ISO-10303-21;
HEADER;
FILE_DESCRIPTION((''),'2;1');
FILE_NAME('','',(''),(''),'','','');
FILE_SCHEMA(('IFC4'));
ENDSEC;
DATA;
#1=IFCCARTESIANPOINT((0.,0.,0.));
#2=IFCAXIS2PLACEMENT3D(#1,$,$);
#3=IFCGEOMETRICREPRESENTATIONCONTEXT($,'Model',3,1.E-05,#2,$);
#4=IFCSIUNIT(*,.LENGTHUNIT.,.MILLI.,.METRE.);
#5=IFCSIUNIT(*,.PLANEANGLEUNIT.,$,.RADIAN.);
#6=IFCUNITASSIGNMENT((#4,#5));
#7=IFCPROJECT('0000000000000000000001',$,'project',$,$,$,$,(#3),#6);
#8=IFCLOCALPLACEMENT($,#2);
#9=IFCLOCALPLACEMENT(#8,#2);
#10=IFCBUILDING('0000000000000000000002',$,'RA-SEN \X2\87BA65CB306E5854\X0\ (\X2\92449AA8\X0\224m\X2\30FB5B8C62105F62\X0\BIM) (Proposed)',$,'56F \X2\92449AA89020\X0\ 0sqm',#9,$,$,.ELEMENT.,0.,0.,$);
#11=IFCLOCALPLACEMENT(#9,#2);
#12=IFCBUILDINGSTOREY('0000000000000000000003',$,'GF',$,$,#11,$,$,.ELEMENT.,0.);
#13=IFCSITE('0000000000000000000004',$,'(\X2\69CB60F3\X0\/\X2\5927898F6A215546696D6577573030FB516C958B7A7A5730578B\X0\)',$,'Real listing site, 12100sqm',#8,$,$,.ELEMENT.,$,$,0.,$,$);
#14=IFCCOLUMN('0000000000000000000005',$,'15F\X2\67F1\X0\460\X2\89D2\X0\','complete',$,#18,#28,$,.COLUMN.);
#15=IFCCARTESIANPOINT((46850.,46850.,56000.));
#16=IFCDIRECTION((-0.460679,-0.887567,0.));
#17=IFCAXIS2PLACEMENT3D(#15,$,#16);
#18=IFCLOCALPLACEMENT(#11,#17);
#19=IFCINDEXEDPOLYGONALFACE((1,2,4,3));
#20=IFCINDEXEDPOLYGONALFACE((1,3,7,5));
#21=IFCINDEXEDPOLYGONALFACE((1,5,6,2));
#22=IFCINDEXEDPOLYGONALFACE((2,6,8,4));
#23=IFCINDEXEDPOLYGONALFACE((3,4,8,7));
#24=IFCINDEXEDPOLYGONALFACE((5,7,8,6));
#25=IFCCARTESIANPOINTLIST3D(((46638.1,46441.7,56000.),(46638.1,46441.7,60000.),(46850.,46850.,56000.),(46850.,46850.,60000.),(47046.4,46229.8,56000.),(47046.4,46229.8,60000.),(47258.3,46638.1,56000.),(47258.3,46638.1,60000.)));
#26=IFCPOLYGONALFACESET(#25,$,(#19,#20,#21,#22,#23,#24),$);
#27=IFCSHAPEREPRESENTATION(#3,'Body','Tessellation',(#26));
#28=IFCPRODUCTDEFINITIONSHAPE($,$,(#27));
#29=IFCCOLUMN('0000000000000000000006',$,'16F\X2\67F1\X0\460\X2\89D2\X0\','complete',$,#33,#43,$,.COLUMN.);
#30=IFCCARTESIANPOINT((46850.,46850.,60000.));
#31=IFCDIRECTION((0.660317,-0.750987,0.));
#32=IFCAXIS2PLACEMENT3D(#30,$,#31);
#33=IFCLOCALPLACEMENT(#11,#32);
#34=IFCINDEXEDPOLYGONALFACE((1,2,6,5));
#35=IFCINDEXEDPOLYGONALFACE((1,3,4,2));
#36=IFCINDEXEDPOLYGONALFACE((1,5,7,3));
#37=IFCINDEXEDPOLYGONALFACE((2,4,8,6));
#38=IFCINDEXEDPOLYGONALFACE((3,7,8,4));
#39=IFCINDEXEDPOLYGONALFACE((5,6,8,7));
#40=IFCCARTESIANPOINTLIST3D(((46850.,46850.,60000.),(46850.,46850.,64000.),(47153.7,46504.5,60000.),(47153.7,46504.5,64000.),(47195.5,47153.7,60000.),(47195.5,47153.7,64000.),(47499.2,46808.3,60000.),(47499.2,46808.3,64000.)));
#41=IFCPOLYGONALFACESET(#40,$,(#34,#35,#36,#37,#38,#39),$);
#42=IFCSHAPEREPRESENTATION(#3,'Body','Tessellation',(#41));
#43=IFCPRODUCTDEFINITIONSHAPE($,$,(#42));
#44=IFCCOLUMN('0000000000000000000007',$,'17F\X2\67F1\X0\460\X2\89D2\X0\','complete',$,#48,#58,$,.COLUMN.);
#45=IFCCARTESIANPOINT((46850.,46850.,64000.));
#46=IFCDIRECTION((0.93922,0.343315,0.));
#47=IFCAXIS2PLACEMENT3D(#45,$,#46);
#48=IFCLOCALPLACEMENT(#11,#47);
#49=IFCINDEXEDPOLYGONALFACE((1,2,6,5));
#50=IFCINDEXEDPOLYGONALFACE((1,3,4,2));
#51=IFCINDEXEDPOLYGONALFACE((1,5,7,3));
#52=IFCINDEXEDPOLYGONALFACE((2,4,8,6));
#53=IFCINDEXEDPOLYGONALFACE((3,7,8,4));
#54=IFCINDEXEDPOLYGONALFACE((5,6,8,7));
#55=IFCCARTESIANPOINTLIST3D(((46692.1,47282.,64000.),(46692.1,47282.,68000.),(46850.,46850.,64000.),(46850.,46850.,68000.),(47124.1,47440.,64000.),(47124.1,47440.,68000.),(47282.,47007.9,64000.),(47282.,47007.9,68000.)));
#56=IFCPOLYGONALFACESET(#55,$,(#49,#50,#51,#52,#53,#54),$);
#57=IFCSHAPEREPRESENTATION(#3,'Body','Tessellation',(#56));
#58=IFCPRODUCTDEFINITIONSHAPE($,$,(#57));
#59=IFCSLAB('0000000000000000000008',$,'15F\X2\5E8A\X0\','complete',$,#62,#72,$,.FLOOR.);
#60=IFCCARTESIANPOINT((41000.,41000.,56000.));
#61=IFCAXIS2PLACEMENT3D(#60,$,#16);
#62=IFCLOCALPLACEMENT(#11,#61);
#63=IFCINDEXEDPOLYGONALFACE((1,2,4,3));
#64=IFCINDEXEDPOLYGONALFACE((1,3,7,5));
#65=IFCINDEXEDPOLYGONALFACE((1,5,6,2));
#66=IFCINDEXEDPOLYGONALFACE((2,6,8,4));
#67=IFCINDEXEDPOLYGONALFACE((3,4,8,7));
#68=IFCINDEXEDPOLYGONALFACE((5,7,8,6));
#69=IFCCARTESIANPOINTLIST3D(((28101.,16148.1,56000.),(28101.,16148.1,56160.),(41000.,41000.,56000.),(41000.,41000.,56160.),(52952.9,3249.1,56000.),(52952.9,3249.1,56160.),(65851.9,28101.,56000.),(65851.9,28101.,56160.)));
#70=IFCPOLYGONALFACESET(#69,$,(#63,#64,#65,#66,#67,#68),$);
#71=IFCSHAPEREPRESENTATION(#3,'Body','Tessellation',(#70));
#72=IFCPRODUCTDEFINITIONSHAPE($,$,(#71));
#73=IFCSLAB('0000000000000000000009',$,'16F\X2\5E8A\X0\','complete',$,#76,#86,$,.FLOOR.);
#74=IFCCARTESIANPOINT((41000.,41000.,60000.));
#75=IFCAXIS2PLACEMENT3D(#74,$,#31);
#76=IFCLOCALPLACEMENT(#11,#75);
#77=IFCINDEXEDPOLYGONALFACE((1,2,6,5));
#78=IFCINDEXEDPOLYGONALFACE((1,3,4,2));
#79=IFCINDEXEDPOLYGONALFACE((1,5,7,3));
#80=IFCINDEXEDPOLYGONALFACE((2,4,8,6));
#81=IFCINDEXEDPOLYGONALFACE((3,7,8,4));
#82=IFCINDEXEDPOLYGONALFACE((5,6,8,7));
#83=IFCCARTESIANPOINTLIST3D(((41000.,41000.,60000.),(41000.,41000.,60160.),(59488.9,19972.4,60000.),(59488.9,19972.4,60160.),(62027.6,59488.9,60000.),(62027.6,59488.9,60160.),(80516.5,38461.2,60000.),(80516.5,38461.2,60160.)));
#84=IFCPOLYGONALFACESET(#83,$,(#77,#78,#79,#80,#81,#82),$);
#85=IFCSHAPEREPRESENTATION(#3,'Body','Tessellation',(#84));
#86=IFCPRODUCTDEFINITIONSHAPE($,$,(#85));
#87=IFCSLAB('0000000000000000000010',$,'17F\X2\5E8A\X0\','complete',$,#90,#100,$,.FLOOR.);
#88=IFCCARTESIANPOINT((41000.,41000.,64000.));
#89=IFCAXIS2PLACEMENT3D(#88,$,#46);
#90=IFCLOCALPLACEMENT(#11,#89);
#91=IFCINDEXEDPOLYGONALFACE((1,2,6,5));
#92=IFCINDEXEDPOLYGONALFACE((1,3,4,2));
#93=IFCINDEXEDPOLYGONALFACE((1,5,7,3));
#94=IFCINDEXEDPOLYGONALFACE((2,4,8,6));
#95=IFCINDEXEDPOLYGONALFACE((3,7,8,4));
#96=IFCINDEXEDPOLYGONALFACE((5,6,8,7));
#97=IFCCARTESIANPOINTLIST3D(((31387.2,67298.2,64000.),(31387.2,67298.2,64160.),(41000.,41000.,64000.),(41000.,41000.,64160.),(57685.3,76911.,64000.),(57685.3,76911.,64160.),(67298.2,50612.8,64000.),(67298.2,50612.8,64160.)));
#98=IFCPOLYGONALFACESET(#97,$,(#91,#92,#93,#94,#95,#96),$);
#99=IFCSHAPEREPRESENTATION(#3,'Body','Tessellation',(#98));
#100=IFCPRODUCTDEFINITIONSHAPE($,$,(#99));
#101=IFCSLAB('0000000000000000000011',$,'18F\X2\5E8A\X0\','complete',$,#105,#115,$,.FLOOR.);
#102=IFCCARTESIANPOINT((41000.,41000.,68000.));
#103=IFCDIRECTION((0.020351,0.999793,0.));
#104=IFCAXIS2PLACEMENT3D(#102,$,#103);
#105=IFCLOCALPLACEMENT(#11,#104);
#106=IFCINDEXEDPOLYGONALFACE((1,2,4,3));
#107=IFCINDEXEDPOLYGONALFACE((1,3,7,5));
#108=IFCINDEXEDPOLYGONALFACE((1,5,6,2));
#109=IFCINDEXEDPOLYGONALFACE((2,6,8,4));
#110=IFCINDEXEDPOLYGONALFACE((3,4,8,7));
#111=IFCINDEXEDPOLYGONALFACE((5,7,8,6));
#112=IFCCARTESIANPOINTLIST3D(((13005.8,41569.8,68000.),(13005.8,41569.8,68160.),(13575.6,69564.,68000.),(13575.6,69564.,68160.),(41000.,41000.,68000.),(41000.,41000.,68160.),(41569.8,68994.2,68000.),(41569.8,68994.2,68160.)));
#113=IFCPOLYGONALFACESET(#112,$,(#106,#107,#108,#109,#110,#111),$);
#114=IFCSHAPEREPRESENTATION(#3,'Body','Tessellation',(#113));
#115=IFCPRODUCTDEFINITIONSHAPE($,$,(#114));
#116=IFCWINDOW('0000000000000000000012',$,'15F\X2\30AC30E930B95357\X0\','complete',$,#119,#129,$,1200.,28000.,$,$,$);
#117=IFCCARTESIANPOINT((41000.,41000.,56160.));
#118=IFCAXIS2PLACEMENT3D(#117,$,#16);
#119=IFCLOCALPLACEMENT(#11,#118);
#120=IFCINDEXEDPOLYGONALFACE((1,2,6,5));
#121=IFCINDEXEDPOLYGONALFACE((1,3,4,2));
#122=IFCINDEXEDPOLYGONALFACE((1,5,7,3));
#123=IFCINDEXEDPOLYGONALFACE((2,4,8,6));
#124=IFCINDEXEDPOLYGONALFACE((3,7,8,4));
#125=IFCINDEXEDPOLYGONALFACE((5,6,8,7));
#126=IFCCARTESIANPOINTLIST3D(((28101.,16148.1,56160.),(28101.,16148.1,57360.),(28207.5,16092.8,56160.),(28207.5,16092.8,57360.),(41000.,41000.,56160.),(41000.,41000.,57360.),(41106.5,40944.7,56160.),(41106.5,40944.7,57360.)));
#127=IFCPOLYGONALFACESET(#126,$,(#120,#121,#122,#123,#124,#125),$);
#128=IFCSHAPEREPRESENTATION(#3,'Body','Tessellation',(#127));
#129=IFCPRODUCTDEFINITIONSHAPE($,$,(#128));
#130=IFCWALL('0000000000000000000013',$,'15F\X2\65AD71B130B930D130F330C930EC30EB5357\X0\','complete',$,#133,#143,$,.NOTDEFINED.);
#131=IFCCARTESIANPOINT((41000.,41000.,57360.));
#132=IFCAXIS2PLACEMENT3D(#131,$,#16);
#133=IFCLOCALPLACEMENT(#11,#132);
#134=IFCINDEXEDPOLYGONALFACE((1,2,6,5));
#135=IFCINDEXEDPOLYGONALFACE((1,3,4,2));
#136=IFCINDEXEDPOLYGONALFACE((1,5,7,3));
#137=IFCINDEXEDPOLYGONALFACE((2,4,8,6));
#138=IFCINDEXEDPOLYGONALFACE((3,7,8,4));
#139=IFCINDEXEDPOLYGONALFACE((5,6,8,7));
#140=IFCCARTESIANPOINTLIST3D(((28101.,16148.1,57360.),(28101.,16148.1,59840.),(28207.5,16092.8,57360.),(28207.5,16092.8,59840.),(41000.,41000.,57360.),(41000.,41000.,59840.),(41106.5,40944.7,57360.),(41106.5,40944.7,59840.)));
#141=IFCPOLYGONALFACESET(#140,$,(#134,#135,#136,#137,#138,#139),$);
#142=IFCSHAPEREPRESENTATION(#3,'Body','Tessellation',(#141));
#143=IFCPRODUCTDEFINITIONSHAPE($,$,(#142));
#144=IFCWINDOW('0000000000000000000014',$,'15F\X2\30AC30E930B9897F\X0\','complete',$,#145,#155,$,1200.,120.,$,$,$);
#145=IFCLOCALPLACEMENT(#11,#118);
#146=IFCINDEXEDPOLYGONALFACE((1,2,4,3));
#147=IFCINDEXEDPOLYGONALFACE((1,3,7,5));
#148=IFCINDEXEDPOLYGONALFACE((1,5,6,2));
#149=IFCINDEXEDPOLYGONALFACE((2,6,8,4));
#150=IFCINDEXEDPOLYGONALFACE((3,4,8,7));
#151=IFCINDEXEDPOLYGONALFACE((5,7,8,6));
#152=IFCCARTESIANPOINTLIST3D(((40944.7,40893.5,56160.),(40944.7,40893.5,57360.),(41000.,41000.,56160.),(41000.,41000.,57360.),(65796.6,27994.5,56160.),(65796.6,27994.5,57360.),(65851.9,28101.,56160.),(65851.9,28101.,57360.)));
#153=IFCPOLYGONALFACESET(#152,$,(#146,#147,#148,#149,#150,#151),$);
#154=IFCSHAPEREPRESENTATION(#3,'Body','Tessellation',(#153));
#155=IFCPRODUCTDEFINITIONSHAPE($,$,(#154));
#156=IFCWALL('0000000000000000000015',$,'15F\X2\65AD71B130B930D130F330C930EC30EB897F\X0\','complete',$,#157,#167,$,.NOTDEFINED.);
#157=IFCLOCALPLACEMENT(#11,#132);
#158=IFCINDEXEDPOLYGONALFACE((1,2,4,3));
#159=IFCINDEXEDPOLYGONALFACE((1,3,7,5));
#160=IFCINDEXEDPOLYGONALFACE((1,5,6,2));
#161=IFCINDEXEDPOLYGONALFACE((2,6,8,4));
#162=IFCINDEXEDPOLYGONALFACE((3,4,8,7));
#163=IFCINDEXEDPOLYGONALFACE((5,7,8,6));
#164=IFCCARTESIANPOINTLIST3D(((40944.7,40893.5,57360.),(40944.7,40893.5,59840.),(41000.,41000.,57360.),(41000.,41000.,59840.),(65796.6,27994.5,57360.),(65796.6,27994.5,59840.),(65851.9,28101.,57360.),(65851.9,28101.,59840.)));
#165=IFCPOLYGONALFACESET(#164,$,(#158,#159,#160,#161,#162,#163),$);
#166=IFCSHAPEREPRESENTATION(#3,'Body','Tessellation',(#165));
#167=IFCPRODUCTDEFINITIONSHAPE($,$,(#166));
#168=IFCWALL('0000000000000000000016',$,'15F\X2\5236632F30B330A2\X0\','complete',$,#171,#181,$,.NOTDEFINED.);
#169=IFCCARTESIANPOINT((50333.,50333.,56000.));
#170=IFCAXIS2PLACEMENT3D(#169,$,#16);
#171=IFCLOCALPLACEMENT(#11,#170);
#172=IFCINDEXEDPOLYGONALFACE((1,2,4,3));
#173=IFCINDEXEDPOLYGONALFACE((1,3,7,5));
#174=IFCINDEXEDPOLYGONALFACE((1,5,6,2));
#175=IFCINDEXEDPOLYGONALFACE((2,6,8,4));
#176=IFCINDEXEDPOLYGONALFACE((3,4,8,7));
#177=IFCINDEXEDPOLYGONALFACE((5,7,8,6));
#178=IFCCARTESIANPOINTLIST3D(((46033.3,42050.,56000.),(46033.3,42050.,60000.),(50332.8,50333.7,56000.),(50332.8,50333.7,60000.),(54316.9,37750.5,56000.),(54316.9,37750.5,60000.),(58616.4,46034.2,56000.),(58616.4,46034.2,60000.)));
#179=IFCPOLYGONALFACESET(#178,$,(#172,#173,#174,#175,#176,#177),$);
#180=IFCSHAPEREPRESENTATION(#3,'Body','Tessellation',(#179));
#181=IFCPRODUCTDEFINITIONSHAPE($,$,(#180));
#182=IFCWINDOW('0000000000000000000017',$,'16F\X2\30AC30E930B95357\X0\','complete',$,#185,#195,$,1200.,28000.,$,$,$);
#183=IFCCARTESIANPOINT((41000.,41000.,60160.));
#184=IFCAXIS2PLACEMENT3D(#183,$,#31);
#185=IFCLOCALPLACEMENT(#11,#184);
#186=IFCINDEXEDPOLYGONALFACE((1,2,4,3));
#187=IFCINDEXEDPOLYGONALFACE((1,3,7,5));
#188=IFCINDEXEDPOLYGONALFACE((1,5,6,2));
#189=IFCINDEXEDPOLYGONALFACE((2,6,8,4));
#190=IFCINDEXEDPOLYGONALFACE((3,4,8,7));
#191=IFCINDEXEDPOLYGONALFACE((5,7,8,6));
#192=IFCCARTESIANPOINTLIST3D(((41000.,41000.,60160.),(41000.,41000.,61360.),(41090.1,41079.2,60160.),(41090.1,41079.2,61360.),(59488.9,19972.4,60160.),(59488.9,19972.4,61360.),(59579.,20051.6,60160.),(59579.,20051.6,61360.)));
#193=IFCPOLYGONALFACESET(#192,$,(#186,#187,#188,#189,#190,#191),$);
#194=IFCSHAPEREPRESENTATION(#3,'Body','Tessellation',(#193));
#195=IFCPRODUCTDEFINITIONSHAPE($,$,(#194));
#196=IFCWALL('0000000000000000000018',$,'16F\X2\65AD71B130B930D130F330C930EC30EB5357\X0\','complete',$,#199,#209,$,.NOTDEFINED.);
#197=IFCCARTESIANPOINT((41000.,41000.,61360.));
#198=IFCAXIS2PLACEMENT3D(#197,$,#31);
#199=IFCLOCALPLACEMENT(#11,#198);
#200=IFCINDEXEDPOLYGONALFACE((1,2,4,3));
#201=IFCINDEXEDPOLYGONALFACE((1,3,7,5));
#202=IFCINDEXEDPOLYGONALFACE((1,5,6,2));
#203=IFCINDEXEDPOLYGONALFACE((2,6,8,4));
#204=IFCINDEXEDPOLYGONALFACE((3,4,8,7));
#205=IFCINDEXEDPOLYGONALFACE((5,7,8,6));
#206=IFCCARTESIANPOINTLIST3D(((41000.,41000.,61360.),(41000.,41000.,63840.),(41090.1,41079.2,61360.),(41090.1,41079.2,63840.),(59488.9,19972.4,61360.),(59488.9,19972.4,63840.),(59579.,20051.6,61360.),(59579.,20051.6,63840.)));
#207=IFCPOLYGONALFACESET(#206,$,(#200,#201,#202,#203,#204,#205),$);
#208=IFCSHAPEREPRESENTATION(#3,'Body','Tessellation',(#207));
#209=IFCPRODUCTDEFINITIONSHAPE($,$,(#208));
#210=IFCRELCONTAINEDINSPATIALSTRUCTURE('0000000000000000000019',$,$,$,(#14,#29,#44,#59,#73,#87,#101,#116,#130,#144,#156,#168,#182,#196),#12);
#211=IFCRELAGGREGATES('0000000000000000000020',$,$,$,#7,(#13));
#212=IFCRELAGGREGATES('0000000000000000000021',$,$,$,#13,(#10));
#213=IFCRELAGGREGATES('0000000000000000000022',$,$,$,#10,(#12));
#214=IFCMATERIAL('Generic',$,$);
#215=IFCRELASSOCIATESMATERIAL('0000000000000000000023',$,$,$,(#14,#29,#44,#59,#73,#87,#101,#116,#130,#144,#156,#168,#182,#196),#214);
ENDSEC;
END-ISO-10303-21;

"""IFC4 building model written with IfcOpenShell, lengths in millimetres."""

from ifc_helpers import new_model, si_unit, frame, frame_2d, origin, place, context, project, spatial, rectangle, extrude, material, element, save


model = new_model("IFC4")

# Units and contexts
model_context = context("Model", 3, precision=1e-05, world=origin())
ifc_project = project(units=[si_unit("LENGTHUNIT", "METRE", prefix="MILLI"), si_unit("PLANEANGLEUNIT", "RADIAN")], contexts=[model_context])

# Site, building, storey
site_placement = place(None, origin())
site = spatial("IfcSite", under=ifc_project, at=site_placement, Name="(構想/大規模商業敷地・公開空地型)", ObjectType="Real listing site, 12100sqm", CompositionType="ELEMENT", RefElevation=0.0)
building_placement = place(site_placement, origin())
building = spatial("IfcBuilding", under=site, at=building_placement, Name="RA-SEN 螺旋の塔 (鉄骨224m・完成形BIM) (Proposed)", ObjectType="56F 鉄骨造 0sqm", CompositionType="ELEMENT", ElevationOfRefHeight=0.0, ElevationOfTerrain=0.0)
storey_placement = place(building_placement, origin())
storey = spatial("IfcBuildingStorey", under=building, at=storey_placement, Name="GF", CompositionType="ELEMENT", Elevation=0.0)

# Columns
ifc_material = material(Name="Generic")
column_1_placement = place(storey_placement, frame((46850.0, 46850.0, 56000.0), x_axis=(-0.460679, -0.887567, 0.0)))
element("IfcColumn", 1, at=column_1_placement, inside=storey, material=ifc_material, Name="15F柱460角", Description="complete", PredefinedType="COLUMN", context=model_context, shape_type="SweptSolid", body=[
    extrude(rectangle(XDim=460.0, YDim=460.0, at=frame_2d((230.0, 230.0))), frame((46850.0, 46850.0, 56000.0), x_axis=(-0.460679, -0.887567, 0.0)), (0.0, 0.0, 1.0), 4000.0),
])
column_2_placement = place(storey_placement, frame((46850.0, 46850.0, 60000.0), x_axis=(0.660317, -0.750987, 0.0)))
element("IfcColumn", 2, at=column_2_placement, inside=storey, material=ifc_material, Name="16F柱460角", Description="complete", PredefinedType="COLUMN", context=model_context, shape_type="SweptSolid", body=[
    extrude(rectangle(XDim=460.0, YDim=460.0, at=frame_2d((230.0, 230.0))), frame((46850.0, 46850.0, 60000.0), x_axis=(0.660317, -0.750987, 0.0)), (0.0, 0.0, 1.0), 4000.0),
])
column_3_placement = place(storey_placement, frame((46850.0, 46850.0, 64000.0), x_axis=(0.93922, 0.343315, 0.0)))
element("IfcColumn", 3, at=column_3_placement, inside=storey, material=ifc_material, Name="17F柱460角", Description="complete", PredefinedType="COLUMN", context=model_context, shape_type="SweptSolid", body=[
    extrude(rectangle(XDim=460.0, YDim=460.0, at=frame_2d((230.0, 230.0))), frame((46850.0, 46850.0, 64000.0), x_axis=(0.93922, 0.343315, 0.0)), (0.0, 0.0, 1.0), 4000.0),
])

# Slabs
slab_1_placement = place(storey_placement, frame((41000.0, 41000.0, 56000.0), x_axis=(-0.460679, -0.887567, 0.0)))
element("IfcSlab", 4, at=slab_1_placement, inside=storey, material=ifc_material, Name="15F床", Description="complete", PredefinedType="FLOOR", context=model_context, shape_type="SweptSolid", body=[
    extrude(rectangle(XDim=28000.0, YDim=28000.0, at=frame_2d((14000.0, 14000.0))), frame((41000.0, 41000.0, 56000.0), x_axis=(-0.460679, -0.887567, 0.0)), (0.0, 0.0, 1.0), 160.0),
])
slab_2_placement = place(storey_placement, frame((41000.0, 41000.0, 60000.0), x_axis=(0.660317, -0.750987, 0.0)))
element("IfcSlab", 5, at=slab_2_placement, inside=storey, material=ifc_material, Name="16F床", Description="complete", PredefinedType="FLOOR", context=model_context, shape_type="SweptSolid", body=[
    extrude(rectangle(XDim=28000.0, YDim=28000.0, at=frame_2d((14000.0, 14000.0))), frame((41000.0, 41000.0, 60000.0), x_axis=(0.660317, -0.750987, 0.0)), (0.0, 0.0, 1.0), 160.0),
])
slab_3_placement = place(storey_placement, frame((41000.0, 41000.0, 64000.0), x_axis=(0.93922, 0.343315, 0.0)))
element("IfcSlab", 6, at=slab_3_placement, inside=storey, material=ifc_material, Name="17F床", Description="complete", PredefinedType="FLOOR", context=model_context, shape_type="SweptSolid", body=[
    extrude(rectangle(XDim=28000.0, YDim=28000.0, at=frame_2d((14000.0, 14000.0))), frame((41000.0, 41000.0, 64000.0), x_axis=(0.93922, 0.343315, 0.0)), (0.0, 0.0, 1.0), 160.0),
])
slab_4_placement = place(storey_placement, frame((41000.0, 41000.0, 68000.0), x_axis=(0.020351, 0.999793, 0.0)))
element("IfcSlab", 7, at=slab_4_placement, inside=storey, material=ifc_material, Name="18F床", Description="complete", PredefinedType="FLOOR", context=model_context, shape_type="SweptSolid", body=[
    extrude(rectangle(XDim=28000.0, YDim=28000.0, at=frame_2d((14000.0, 14000.0))), frame((41000.0, 41000.0, 68000.0), x_axis=(0.020351, 0.999793, 0.0)), (0.0, 0.0, 1.0), 160.0),
])

# Window
window_1_placement = place(storey_placement, frame((41000.0, 41000.0, 56160.0), x_axis=(-0.460679, -0.887567, 0.0)))
element("IfcWindow", 8, at=window_1_placement, inside=storey, material=ifc_material, Name="15Fガラス南", Description="complete", OverallHeight=1200.0, OverallWidth=28000.0, context=model_context, shape_type="SweptSolid", body=[
    extrude(rectangle(XDim=28000.0, YDim=120.0, at=frame_2d((14000.0, 60.0))), frame((41000.0, 41000.0, 56160.0), x_axis=(-0.460679, -0.887567, 0.0)), (0.0, 0.0, 1.0), 1200.0),
])

# Wall
wall_1_placement = place(storey_placement, frame((41000.0, 41000.0, 57360.0), x_axis=(-0.460679, -0.887567, 0.0)))
element("IfcWall", 9, at=wall_1_placement, inside=storey, material=ifc_material, Name="15F断熱スパンドレル南", Description="complete", PredefinedType="NOTDEFINED", context=model_context, shape_type="SweptSolid", body=[
    extrude(rectangle(XDim=28000.0, YDim=120.0, at=frame_2d((14000.0, 60.0))), frame((41000.0, 41000.0, 57360.0), x_axis=(-0.460679, -0.887567, 0.0)), (0.0, 0.0, 1.0), 2480.0),
])

# Window
window_2_placement = place(storey_placement, frame((41000.0, 41000.0, 56160.0), x_axis=(-0.460679, -0.887567, 0.0)))
element("IfcWindow", 10, at=window_2_placement, inside=storey, material=ifc_material, Name="15Fガラス西", Description="complete", OverallHeight=1200.0, OverallWidth=120.0, context=model_context, shape_type="SweptSolid", body=[
    extrude(rectangle(XDim=120.0, YDim=28000.0, at=frame_2d((60.0, 14000.0))), frame((41000.0, 41000.0, 56160.0), x_axis=(-0.460679, -0.887567, 0.0)), (0.0, 0.0, 1.0), 1200.0),
])

# Walls
wall_2_placement = place(storey_placement, frame((41000.0, 41000.0, 57360.0), x_axis=(-0.460679, -0.887567, 0.0)))
element("IfcWall", 11, at=wall_2_placement, inside=storey, material=ifc_material, Name="15F断熱スパンドレル西", Description="complete", PredefinedType="NOTDEFINED", context=model_context, shape_type="SweptSolid", body=[
    extrude(rectangle(XDim=120.0, YDim=28000.0, at=frame_2d((60.0, 14000.0))), frame((41000.0, 41000.0, 57360.0), x_axis=(-0.460679, -0.887567, 0.0)), (0.0, 0.0, 1.0), 2480.0),
])
wall_3_placement = place(storey_placement, frame((50333.0, 50333.0, 56000.0), x_axis=(-0.460679, -0.887567, 0.0)))
element("IfcWall", 12, at=wall_3_placement, inside=storey, material=ifc_material, Name="15F制振コア", Description="complete", PredefinedType="NOTDEFINED", context=model_context, shape_type="SweptSolid", body=[
    extrude(rectangle(XDim=9333.0, YDim=9333.0, at=frame_2d((4666.0, 4666.0))), frame((50333.0, 50333.0, 56000.0), x_axis=(-0.460679, -0.887567, 0.0)), (0.0, 0.0, 1.0), 4000.0),
])

# Window
window_3_placement = place(storey_placement, frame((41000.0, 41000.0, 60160.0), x_axis=(0.660317, -0.750987, 0.0)))
element("IfcWindow", 13, at=window_3_placement, inside=storey, material=ifc_material, Name="16Fガラス南", Description="complete", OverallHeight=1200.0, OverallWidth=28000.0, context=model_context, shape_type="SweptSolid", body=[
    extrude(rectangle(XDim=28000.0, YDim=120.0, at=frame_2d((14000.0, 60.0))), frame((41000.0, 41000.0, 60160.0), x_axis=(0.660317, -0.750987, 0.0)), (0.0, 0.0, 1.0), 1200.0),
])

# Wall
wall_4_placement = place(storey_placement, frame((41000.0, 41000.0, 61360.0), x_axis=(0.660317, -0.750987, 0.0)))
element("IfcWall", 14, at=wall_4_placement, inside=storey, material=ifc_material, Name="16F断熱スパンドレル南", Description="complete", PredefinedType="NOTDEFINED", context=model_context, shape_type="SweptSolid", body=[
    extrude(rectangle(XDim=28000.0, YDim=120.0, at=frame_2d((14000.0, 60.0))), frame((41000.0, 41000.0, 61360.0), x_axis=(0.660317, -0.750987, 0.0)), (0.0, 0.0, 1.0), 2480.0),
])

save(model, "model.ifc")
